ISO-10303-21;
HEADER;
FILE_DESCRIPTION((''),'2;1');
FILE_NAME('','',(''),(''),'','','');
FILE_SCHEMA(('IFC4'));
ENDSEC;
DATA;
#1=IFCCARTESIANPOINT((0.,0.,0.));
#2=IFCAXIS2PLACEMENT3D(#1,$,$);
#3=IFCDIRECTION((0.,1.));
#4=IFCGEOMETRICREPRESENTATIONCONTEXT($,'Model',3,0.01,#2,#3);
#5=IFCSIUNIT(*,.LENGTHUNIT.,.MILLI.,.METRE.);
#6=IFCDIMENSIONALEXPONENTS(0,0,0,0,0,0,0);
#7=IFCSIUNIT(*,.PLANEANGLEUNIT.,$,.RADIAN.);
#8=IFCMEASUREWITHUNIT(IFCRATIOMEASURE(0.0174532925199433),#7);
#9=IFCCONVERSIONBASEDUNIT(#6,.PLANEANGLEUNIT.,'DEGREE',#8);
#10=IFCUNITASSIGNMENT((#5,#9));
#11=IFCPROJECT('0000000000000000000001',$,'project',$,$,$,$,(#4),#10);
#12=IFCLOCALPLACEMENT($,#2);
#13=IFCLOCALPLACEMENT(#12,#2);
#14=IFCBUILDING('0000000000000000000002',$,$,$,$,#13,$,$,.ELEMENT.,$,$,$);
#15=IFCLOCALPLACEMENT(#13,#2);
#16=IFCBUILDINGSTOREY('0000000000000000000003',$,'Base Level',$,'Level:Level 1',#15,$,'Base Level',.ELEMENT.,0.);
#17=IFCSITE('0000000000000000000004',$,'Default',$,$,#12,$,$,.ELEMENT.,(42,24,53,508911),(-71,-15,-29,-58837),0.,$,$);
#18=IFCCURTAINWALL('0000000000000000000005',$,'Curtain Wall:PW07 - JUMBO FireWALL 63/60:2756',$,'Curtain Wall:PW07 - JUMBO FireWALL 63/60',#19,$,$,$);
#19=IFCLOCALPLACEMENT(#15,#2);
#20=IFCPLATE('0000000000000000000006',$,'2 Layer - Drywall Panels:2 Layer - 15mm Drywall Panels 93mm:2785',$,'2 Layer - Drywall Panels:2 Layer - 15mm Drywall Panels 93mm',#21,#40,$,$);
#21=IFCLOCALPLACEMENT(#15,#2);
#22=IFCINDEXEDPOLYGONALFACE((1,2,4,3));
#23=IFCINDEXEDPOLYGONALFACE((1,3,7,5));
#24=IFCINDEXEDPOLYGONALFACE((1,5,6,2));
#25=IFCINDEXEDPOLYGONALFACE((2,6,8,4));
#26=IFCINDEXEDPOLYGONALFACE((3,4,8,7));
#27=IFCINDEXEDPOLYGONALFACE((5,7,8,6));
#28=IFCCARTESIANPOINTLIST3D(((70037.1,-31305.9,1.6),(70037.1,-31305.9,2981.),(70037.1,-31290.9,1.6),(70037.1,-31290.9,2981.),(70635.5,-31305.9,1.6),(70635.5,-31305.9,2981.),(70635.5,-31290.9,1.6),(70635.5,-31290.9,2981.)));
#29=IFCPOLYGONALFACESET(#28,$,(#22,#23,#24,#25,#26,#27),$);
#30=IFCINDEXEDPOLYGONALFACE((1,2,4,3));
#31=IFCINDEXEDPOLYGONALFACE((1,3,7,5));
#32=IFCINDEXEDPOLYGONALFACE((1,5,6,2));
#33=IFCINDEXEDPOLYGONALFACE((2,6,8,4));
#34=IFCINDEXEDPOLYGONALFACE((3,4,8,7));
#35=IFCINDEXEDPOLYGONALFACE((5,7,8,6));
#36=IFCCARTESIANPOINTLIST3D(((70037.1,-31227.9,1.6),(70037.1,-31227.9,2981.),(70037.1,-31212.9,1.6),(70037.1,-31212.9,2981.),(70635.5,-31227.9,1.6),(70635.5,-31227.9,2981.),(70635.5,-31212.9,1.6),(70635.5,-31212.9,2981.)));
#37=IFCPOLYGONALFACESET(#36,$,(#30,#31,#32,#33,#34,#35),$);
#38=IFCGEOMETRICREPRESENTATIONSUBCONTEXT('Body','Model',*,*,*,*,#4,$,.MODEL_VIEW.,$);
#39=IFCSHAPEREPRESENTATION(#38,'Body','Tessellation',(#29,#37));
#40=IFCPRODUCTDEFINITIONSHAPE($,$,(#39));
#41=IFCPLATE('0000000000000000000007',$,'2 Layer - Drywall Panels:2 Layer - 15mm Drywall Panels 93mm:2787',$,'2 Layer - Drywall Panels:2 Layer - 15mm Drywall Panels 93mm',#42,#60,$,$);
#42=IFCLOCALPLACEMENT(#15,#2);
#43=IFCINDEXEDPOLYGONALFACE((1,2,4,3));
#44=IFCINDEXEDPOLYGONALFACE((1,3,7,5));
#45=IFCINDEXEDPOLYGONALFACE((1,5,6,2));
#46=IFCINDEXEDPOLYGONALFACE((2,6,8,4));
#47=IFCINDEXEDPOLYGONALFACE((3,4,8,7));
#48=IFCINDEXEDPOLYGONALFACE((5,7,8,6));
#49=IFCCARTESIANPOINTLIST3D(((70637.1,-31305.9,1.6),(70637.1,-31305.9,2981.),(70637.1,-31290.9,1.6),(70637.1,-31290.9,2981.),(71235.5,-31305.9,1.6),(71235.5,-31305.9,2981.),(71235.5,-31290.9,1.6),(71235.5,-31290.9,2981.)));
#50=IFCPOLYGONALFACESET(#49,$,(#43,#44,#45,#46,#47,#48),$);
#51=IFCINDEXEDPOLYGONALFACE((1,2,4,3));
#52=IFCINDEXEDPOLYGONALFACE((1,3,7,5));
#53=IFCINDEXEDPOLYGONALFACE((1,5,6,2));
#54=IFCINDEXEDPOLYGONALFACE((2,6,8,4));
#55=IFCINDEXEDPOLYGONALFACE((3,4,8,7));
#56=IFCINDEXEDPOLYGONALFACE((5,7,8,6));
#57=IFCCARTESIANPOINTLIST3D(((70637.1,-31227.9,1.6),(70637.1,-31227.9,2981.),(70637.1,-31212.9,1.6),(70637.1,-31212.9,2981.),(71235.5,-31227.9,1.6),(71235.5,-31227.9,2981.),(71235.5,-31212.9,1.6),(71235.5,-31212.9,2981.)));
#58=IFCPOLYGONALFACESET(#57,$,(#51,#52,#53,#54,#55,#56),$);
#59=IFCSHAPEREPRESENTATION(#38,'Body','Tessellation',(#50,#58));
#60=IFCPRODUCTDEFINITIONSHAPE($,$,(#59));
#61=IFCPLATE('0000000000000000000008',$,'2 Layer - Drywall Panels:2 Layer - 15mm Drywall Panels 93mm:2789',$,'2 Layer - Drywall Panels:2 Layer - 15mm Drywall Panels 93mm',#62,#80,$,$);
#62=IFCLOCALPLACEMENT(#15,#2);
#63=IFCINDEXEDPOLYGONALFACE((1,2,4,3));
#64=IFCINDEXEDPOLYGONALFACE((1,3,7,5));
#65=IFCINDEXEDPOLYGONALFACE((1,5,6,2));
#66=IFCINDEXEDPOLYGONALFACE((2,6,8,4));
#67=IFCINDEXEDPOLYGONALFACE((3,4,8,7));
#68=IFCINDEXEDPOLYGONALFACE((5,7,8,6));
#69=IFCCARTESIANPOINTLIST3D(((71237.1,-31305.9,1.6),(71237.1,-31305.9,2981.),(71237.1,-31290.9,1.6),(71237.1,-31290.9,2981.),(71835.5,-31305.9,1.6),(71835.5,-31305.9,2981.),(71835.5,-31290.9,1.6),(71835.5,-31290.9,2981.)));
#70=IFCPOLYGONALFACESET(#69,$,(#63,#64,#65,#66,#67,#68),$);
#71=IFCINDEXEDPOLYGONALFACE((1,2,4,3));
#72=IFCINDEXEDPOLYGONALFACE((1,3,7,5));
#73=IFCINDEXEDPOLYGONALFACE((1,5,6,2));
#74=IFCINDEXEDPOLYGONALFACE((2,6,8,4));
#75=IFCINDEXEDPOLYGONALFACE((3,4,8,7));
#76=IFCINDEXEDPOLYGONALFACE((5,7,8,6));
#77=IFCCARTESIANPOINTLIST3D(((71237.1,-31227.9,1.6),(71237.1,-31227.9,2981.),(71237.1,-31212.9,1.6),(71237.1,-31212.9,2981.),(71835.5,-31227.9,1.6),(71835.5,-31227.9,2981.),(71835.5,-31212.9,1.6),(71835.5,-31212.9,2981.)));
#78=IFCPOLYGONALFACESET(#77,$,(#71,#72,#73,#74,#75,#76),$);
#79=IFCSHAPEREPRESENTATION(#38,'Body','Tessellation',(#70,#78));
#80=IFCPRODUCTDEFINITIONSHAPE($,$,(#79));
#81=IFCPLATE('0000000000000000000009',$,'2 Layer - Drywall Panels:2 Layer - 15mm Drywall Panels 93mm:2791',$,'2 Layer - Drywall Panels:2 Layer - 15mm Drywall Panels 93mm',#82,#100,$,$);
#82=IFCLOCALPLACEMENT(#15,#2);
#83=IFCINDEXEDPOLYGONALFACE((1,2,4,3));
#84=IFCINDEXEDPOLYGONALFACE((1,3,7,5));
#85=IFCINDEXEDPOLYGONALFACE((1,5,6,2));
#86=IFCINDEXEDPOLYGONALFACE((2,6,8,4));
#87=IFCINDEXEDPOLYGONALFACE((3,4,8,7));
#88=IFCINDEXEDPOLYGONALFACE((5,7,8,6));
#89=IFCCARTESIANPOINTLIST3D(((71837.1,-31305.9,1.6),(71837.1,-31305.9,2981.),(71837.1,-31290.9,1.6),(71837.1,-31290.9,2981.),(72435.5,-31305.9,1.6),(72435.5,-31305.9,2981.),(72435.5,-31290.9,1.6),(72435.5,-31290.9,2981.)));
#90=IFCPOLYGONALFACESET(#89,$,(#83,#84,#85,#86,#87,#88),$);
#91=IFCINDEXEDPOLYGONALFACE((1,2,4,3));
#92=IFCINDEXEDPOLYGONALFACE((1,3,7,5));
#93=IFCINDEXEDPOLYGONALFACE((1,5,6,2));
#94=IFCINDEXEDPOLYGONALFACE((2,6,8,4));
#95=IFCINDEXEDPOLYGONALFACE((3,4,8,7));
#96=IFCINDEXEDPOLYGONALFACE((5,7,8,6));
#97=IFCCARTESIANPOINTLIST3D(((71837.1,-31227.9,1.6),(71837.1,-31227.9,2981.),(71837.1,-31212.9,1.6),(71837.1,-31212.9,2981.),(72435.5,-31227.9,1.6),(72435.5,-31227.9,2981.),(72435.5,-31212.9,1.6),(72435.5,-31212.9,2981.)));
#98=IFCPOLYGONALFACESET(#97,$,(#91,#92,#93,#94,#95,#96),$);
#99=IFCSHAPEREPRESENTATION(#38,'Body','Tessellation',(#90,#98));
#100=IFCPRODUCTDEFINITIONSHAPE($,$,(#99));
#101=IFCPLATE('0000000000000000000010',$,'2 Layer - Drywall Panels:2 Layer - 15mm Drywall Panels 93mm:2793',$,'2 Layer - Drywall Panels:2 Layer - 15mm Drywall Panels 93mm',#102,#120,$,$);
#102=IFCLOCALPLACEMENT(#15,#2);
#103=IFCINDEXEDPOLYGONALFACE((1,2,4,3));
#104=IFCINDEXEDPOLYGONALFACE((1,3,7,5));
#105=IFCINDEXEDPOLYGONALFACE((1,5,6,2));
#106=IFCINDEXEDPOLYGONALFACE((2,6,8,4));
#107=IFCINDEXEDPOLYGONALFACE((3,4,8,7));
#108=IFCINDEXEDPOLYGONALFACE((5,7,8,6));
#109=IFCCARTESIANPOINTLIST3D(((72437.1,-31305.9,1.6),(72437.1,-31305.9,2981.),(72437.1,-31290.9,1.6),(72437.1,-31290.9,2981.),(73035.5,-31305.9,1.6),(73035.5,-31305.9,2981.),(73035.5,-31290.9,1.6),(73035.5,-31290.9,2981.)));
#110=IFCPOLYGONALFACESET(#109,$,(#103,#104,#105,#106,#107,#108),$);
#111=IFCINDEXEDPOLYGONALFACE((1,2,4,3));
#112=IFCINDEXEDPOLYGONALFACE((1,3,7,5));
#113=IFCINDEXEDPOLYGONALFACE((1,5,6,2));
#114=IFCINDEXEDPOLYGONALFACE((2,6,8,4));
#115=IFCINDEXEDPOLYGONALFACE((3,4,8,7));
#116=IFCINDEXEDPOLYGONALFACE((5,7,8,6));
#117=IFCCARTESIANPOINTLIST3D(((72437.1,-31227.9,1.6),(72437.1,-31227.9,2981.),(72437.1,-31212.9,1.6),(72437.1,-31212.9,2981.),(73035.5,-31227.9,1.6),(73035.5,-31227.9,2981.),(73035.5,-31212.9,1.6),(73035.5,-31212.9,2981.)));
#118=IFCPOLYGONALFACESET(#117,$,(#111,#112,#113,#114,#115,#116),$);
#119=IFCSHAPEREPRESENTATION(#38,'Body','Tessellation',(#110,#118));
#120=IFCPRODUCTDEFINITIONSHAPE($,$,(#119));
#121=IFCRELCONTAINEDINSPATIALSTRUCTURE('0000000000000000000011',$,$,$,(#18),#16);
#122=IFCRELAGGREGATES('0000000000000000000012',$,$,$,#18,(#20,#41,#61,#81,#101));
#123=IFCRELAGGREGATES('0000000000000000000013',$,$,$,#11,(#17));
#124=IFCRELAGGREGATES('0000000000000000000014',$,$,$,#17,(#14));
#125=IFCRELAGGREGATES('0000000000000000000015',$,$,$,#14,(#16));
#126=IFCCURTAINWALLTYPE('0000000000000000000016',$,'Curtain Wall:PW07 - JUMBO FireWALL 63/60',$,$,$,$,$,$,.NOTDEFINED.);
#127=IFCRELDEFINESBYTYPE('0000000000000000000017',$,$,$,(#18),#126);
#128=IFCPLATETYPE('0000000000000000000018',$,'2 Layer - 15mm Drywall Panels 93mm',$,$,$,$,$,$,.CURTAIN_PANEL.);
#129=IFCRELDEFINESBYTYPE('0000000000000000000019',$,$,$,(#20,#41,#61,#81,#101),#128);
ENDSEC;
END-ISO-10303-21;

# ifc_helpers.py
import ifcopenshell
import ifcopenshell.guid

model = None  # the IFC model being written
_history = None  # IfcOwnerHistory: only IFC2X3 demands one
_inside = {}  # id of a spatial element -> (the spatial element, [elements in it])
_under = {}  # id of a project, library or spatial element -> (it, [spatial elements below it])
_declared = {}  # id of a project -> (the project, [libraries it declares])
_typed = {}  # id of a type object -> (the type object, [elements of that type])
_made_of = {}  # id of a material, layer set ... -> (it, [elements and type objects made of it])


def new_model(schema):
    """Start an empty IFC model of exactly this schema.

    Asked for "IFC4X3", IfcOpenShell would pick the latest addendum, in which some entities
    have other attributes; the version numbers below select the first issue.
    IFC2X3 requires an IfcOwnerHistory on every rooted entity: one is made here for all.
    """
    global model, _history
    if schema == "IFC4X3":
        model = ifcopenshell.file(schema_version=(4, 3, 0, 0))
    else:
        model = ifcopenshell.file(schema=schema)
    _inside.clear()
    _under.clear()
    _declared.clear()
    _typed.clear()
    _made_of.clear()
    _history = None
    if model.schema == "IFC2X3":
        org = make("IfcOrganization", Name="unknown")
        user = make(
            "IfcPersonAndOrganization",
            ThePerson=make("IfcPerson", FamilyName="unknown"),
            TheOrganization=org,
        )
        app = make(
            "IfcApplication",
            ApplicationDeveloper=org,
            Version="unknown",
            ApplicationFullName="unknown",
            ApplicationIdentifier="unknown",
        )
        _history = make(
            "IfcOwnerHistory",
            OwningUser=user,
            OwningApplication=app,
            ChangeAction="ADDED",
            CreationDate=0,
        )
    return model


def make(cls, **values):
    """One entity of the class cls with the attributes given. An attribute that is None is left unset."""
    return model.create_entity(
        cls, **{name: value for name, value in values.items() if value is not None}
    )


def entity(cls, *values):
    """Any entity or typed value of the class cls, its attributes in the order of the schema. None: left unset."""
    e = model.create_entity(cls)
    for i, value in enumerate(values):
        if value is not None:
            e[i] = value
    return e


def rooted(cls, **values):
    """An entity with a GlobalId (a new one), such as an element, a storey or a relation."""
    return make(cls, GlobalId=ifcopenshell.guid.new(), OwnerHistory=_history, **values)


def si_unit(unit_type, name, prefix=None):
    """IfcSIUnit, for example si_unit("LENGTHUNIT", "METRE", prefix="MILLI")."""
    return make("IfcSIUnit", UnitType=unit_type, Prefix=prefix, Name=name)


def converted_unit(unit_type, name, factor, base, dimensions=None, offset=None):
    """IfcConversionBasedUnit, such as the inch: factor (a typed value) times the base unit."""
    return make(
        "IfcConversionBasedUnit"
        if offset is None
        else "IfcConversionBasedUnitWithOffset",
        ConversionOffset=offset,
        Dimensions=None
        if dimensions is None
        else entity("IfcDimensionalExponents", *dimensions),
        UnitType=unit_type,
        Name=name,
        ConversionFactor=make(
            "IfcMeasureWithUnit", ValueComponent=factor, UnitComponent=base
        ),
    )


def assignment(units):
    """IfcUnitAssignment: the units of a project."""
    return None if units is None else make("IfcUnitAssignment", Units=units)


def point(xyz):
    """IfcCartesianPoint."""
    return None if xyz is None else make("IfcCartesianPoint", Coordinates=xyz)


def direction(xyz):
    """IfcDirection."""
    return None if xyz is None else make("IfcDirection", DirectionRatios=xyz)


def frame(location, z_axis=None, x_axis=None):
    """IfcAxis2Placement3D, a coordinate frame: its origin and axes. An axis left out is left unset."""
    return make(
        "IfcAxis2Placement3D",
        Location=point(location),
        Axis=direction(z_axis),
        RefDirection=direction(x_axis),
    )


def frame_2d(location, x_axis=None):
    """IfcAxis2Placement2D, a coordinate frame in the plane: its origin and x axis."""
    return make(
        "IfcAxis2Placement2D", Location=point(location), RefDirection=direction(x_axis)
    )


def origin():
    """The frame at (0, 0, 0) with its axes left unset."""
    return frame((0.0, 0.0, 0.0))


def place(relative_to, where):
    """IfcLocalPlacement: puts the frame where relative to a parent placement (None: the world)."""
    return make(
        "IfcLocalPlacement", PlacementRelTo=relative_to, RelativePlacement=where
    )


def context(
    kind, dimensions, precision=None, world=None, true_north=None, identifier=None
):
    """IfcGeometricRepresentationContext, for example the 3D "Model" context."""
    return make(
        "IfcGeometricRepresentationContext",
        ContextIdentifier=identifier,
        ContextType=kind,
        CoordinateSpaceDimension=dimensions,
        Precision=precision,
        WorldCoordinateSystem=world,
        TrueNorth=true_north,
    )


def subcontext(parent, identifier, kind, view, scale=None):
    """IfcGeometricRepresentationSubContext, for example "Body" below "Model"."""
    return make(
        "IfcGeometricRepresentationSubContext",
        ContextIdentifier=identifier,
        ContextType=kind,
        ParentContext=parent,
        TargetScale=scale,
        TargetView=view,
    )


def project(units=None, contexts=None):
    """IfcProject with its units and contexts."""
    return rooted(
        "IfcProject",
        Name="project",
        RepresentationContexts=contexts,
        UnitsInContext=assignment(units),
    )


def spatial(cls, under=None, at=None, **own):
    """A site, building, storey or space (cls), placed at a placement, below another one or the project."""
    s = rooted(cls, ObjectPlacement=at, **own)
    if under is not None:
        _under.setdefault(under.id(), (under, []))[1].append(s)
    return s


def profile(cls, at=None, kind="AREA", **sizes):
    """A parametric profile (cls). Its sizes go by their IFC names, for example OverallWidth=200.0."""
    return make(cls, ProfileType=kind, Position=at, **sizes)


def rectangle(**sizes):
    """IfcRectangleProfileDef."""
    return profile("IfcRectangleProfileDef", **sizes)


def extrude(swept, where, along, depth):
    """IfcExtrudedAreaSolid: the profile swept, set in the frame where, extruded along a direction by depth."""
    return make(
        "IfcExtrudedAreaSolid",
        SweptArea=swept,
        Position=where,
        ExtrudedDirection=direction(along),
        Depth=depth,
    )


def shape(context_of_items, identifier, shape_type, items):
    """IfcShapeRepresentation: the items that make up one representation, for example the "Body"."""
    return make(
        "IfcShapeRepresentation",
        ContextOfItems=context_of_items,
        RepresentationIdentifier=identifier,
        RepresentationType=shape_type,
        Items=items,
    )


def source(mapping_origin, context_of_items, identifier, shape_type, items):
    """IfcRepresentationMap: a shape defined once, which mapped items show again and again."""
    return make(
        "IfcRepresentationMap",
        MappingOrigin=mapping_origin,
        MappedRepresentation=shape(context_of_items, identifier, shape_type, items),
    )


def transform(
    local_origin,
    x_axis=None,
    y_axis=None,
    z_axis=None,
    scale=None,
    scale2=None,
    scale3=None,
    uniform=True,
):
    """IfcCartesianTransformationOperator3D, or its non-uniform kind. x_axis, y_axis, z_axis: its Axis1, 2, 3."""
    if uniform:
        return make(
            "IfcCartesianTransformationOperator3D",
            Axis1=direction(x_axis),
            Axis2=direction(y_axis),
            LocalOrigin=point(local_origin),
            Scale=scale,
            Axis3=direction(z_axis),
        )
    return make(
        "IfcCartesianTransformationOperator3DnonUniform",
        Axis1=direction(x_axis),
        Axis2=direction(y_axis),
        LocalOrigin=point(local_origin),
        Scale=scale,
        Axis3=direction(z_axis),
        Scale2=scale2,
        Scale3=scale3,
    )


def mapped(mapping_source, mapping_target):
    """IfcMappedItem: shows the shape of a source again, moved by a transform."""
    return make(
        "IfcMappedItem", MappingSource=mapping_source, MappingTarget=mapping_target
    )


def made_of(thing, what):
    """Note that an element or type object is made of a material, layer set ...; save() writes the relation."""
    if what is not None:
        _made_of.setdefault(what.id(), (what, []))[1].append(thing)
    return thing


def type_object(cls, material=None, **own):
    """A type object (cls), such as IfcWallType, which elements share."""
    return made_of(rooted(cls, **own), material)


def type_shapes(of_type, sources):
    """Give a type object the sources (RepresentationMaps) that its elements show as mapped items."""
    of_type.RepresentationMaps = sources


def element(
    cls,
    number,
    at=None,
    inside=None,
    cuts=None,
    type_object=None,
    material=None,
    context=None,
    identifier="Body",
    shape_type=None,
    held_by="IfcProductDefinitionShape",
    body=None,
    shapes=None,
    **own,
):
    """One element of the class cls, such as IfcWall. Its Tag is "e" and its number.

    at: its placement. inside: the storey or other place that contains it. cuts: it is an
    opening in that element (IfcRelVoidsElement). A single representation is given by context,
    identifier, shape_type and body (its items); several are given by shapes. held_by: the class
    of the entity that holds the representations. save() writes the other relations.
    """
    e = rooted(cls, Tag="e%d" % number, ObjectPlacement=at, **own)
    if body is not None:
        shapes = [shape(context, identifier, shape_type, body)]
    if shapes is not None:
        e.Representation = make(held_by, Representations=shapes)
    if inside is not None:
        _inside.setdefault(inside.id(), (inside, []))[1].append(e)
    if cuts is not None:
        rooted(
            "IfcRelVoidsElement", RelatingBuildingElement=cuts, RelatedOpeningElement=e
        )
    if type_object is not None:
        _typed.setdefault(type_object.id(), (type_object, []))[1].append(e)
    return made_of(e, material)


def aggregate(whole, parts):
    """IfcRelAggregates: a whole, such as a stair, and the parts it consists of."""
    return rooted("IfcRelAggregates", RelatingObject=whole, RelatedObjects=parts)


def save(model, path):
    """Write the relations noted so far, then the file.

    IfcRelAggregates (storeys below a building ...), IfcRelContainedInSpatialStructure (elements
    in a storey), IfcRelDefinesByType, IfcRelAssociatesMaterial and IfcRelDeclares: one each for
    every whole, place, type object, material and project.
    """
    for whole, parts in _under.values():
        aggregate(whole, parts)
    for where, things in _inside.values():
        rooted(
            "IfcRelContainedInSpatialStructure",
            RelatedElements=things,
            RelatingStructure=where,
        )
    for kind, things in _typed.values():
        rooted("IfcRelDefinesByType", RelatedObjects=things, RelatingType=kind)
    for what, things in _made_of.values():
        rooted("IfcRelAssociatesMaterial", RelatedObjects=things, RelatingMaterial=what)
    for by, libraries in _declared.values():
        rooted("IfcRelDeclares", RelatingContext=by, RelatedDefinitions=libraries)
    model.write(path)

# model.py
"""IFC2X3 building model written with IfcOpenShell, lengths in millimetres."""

from ifc_helpers import new_model, entity, si_unit, converted_unit, direction, frame, frame_2d, origin, place, context, subcontext, project, spatial, rectangle, extrude, source, transform, mapped, type_object, type_shapes, element, aggregate, save


model = new_model("IFC2X3")

# Units and contexts
model_context = context("Model", 3, precision=0.01, world=origin(), true_north=direction((0.0, 1.0)))
body_context = subcontext(model_context, "Body", "Model", "MODEL_VIEW")
ifc_project = project(units=[si_unit("LENGTHUNIT", "METRE", prefix="MILLI"), converted_unit("PLANEANGLEUNIT", "DEGREE", entity("IfcRatioMeasure", 0.0174532925199433), si_unit("PLANEANGLEUNIT", "RADIAN"), dimensions=[0, 0, 0, 0, 0, 0, 0])], contexts=[model_context])

# Site, building, storey
site_placement = place(None, origin())
site = spatial("IfcSite", under=ifc_project, at=site_placement, Name="Default", CompositionType="ELEMENT", RefLatitude=(42, 24, 53, 508911), RefLongitude=(-71, -15, -29, -58837), RefElevation=0.0)
building_placement = place(site_placement, origin())
building = spatial("IfcBuilding", under=site, at=building_placement, CompositionType="ELEMENT")
storey_placement = place(building_placement, origin())
storey = spatial("IfcBuildingStorey", under=building, at=storey_placement, Name="Base Level", ObjectType="Level:Level 1", LongName="Base Level", CompositionType="ELEMENT", Elevation=0.0)

# Curtain wall, plates
curtain_wall_type = type_object("IfcCurtainWallType", Name="Curtain Wall:PW07 - JUMBO FireWALL 63/60", PredefinedType="NOTDEFINED")
curtain_wall_placement = place(building_placement, origin())
curtain_wall = element("IfcCurtainWall", 1, at=curtain_wall_placement, inside=storey, type_object=curtain_wall_type, Name="Curtain Wall:PW07 - JUMBO FireWALL 63/60:2756", ObjectType="Curtain Wall:PW07 - JUMBO FireWALL 63/60")
plate_type = type_object("IfcPlateType", Name="2 Layer - 15mm Drywall Panels 93mm", PredefinedType="CURTAIN_PANEL")
shared_shape_1 = source(origin(), body_context, "Body", "SweptSolid", [
    extrude(rectangle(XDim=598.4, YDim=15.0, at=frame_2d((0.0, 0.0), x_axis=(1.0, 0.0))), frame((0.0, -39.0, 0.0), z_axis=(0.0, 0.0, 1.0), x_axis=(-1.0, 0.0, 0.0)), (0.0, 0.0, 1.0), 2979.4),
    extrude(rectangle(XDim=15.0, YDim=598.4, at=frame_2d((0.0, 0.0), x_axis=(1.0, 0.0))), frame((0.0, 39.0, 0.0), z_axis=(0.0, 0.0, 1.0), x_axis=(0.0, 1.0, 0.0)), (0.0, 0.0, 1.0), 2979.4),
])
type_shapes(plate_type, [shared_shape_1])
plate_1_placement = place(curtain_wall_placement, frame((70336.3, -31259.4, 1.6)))
plate_1 = element("IfcPlate", 2, at=plate_1_placement, type_object=plate_type, Name="2 Layer - Drywall Panels:2 Layer - 15mm Drywall Panels 93mm:2785", ObjectType="2 Layer - Drywall Panels:2 Layer - 15mm Drywall Panels 93mm", context=body_context, shape_type="MappedRepresentation", body=[
    mapped(shared_shape_1, transform((0.0, 0.0, 0.0), scale=1.0)),
])
plate_2_placement = place(curtain_wall_placement, frame((70936.3, -31259.4, 1.6)))
plate_2 = element("IfcPlate", 3, at=plate_2_placement, type_object=plate_type, Name="2 Layer - Drywall Panels:2 Layer - 15mm Drywall Panels 93mm:2787", ObjectType="2 Layer - Drywall Panels:2 Layer - 15mm Drywall Panels 93mm", context=body_context, shape_type="MappedRepresentation", body=[
    mapped(shared_shape_1, transform((0.0, 0.0, 0.0), scale=1.0)),
])
plate_3_placement = place(curtain_wall_placement, frame((71536.3, -31259.4, 1.6)))
plate_3 = element("IfcPlate", 4, at=plate_3_placement, type_object=plate_type, Name="2 Layer - Drywall Panels:2 Layer - 15mm Drywall Panels 93mm:2789", ObjectType="2 Layer - Drywall Panels:2 Layer - 15mm Drywall Panels 93mm", context=body_context, shape_type="MappedRepresentation", body=[
    mapped(shared_shape_1, transform((0.0, 0.0, 0.0), scale=1.0)),
])
plate_4_placement = place(curtain_wall_placement, frame((72136.3, -31259.4, 1.6)))
plate_4 = element("IfcPlate", 5, at=plate_4_placement, type_object=plate_type, Name="2 Layer - Drywall Panels:2 Layer - 15mm Drywall Panels 93mm:2791", ObjectType="2 Layer - Drywall Panels:2 Layer - 15mm Drywall Panels 93mm", context=body_context, shape_type="MappedRepresentation", body=[
    mapped(shared_shape_1, transform((0.0, 0.0, 0.0), scale=1.0)),
])
plate_5_placement = place(curtain_wall_placement, frame((72736.3, -31259.4, 1.6)))
plate_5 = element("IfcPlate", 6, at=plate_5_placement, type_object=plate_type, Name="2 Layer - Drywall Panels:2 Layer - 15mm Drywall Panels 93mm:2793", ObjectType="2 Layer - Drywall Panels:2 Layer - 15mm Drywall Panels 93mm", context=body_context, shape_type="MappedRepresentation", body=[
    mapped(shared_shape_1, transform((0.0, 0.0, 0.0), scale=1.0)),
])
aggregate(curtain_wall, [plate_1, plate_2, plate_3, plate_4, plate_5])

save(model, "model.ifc")
